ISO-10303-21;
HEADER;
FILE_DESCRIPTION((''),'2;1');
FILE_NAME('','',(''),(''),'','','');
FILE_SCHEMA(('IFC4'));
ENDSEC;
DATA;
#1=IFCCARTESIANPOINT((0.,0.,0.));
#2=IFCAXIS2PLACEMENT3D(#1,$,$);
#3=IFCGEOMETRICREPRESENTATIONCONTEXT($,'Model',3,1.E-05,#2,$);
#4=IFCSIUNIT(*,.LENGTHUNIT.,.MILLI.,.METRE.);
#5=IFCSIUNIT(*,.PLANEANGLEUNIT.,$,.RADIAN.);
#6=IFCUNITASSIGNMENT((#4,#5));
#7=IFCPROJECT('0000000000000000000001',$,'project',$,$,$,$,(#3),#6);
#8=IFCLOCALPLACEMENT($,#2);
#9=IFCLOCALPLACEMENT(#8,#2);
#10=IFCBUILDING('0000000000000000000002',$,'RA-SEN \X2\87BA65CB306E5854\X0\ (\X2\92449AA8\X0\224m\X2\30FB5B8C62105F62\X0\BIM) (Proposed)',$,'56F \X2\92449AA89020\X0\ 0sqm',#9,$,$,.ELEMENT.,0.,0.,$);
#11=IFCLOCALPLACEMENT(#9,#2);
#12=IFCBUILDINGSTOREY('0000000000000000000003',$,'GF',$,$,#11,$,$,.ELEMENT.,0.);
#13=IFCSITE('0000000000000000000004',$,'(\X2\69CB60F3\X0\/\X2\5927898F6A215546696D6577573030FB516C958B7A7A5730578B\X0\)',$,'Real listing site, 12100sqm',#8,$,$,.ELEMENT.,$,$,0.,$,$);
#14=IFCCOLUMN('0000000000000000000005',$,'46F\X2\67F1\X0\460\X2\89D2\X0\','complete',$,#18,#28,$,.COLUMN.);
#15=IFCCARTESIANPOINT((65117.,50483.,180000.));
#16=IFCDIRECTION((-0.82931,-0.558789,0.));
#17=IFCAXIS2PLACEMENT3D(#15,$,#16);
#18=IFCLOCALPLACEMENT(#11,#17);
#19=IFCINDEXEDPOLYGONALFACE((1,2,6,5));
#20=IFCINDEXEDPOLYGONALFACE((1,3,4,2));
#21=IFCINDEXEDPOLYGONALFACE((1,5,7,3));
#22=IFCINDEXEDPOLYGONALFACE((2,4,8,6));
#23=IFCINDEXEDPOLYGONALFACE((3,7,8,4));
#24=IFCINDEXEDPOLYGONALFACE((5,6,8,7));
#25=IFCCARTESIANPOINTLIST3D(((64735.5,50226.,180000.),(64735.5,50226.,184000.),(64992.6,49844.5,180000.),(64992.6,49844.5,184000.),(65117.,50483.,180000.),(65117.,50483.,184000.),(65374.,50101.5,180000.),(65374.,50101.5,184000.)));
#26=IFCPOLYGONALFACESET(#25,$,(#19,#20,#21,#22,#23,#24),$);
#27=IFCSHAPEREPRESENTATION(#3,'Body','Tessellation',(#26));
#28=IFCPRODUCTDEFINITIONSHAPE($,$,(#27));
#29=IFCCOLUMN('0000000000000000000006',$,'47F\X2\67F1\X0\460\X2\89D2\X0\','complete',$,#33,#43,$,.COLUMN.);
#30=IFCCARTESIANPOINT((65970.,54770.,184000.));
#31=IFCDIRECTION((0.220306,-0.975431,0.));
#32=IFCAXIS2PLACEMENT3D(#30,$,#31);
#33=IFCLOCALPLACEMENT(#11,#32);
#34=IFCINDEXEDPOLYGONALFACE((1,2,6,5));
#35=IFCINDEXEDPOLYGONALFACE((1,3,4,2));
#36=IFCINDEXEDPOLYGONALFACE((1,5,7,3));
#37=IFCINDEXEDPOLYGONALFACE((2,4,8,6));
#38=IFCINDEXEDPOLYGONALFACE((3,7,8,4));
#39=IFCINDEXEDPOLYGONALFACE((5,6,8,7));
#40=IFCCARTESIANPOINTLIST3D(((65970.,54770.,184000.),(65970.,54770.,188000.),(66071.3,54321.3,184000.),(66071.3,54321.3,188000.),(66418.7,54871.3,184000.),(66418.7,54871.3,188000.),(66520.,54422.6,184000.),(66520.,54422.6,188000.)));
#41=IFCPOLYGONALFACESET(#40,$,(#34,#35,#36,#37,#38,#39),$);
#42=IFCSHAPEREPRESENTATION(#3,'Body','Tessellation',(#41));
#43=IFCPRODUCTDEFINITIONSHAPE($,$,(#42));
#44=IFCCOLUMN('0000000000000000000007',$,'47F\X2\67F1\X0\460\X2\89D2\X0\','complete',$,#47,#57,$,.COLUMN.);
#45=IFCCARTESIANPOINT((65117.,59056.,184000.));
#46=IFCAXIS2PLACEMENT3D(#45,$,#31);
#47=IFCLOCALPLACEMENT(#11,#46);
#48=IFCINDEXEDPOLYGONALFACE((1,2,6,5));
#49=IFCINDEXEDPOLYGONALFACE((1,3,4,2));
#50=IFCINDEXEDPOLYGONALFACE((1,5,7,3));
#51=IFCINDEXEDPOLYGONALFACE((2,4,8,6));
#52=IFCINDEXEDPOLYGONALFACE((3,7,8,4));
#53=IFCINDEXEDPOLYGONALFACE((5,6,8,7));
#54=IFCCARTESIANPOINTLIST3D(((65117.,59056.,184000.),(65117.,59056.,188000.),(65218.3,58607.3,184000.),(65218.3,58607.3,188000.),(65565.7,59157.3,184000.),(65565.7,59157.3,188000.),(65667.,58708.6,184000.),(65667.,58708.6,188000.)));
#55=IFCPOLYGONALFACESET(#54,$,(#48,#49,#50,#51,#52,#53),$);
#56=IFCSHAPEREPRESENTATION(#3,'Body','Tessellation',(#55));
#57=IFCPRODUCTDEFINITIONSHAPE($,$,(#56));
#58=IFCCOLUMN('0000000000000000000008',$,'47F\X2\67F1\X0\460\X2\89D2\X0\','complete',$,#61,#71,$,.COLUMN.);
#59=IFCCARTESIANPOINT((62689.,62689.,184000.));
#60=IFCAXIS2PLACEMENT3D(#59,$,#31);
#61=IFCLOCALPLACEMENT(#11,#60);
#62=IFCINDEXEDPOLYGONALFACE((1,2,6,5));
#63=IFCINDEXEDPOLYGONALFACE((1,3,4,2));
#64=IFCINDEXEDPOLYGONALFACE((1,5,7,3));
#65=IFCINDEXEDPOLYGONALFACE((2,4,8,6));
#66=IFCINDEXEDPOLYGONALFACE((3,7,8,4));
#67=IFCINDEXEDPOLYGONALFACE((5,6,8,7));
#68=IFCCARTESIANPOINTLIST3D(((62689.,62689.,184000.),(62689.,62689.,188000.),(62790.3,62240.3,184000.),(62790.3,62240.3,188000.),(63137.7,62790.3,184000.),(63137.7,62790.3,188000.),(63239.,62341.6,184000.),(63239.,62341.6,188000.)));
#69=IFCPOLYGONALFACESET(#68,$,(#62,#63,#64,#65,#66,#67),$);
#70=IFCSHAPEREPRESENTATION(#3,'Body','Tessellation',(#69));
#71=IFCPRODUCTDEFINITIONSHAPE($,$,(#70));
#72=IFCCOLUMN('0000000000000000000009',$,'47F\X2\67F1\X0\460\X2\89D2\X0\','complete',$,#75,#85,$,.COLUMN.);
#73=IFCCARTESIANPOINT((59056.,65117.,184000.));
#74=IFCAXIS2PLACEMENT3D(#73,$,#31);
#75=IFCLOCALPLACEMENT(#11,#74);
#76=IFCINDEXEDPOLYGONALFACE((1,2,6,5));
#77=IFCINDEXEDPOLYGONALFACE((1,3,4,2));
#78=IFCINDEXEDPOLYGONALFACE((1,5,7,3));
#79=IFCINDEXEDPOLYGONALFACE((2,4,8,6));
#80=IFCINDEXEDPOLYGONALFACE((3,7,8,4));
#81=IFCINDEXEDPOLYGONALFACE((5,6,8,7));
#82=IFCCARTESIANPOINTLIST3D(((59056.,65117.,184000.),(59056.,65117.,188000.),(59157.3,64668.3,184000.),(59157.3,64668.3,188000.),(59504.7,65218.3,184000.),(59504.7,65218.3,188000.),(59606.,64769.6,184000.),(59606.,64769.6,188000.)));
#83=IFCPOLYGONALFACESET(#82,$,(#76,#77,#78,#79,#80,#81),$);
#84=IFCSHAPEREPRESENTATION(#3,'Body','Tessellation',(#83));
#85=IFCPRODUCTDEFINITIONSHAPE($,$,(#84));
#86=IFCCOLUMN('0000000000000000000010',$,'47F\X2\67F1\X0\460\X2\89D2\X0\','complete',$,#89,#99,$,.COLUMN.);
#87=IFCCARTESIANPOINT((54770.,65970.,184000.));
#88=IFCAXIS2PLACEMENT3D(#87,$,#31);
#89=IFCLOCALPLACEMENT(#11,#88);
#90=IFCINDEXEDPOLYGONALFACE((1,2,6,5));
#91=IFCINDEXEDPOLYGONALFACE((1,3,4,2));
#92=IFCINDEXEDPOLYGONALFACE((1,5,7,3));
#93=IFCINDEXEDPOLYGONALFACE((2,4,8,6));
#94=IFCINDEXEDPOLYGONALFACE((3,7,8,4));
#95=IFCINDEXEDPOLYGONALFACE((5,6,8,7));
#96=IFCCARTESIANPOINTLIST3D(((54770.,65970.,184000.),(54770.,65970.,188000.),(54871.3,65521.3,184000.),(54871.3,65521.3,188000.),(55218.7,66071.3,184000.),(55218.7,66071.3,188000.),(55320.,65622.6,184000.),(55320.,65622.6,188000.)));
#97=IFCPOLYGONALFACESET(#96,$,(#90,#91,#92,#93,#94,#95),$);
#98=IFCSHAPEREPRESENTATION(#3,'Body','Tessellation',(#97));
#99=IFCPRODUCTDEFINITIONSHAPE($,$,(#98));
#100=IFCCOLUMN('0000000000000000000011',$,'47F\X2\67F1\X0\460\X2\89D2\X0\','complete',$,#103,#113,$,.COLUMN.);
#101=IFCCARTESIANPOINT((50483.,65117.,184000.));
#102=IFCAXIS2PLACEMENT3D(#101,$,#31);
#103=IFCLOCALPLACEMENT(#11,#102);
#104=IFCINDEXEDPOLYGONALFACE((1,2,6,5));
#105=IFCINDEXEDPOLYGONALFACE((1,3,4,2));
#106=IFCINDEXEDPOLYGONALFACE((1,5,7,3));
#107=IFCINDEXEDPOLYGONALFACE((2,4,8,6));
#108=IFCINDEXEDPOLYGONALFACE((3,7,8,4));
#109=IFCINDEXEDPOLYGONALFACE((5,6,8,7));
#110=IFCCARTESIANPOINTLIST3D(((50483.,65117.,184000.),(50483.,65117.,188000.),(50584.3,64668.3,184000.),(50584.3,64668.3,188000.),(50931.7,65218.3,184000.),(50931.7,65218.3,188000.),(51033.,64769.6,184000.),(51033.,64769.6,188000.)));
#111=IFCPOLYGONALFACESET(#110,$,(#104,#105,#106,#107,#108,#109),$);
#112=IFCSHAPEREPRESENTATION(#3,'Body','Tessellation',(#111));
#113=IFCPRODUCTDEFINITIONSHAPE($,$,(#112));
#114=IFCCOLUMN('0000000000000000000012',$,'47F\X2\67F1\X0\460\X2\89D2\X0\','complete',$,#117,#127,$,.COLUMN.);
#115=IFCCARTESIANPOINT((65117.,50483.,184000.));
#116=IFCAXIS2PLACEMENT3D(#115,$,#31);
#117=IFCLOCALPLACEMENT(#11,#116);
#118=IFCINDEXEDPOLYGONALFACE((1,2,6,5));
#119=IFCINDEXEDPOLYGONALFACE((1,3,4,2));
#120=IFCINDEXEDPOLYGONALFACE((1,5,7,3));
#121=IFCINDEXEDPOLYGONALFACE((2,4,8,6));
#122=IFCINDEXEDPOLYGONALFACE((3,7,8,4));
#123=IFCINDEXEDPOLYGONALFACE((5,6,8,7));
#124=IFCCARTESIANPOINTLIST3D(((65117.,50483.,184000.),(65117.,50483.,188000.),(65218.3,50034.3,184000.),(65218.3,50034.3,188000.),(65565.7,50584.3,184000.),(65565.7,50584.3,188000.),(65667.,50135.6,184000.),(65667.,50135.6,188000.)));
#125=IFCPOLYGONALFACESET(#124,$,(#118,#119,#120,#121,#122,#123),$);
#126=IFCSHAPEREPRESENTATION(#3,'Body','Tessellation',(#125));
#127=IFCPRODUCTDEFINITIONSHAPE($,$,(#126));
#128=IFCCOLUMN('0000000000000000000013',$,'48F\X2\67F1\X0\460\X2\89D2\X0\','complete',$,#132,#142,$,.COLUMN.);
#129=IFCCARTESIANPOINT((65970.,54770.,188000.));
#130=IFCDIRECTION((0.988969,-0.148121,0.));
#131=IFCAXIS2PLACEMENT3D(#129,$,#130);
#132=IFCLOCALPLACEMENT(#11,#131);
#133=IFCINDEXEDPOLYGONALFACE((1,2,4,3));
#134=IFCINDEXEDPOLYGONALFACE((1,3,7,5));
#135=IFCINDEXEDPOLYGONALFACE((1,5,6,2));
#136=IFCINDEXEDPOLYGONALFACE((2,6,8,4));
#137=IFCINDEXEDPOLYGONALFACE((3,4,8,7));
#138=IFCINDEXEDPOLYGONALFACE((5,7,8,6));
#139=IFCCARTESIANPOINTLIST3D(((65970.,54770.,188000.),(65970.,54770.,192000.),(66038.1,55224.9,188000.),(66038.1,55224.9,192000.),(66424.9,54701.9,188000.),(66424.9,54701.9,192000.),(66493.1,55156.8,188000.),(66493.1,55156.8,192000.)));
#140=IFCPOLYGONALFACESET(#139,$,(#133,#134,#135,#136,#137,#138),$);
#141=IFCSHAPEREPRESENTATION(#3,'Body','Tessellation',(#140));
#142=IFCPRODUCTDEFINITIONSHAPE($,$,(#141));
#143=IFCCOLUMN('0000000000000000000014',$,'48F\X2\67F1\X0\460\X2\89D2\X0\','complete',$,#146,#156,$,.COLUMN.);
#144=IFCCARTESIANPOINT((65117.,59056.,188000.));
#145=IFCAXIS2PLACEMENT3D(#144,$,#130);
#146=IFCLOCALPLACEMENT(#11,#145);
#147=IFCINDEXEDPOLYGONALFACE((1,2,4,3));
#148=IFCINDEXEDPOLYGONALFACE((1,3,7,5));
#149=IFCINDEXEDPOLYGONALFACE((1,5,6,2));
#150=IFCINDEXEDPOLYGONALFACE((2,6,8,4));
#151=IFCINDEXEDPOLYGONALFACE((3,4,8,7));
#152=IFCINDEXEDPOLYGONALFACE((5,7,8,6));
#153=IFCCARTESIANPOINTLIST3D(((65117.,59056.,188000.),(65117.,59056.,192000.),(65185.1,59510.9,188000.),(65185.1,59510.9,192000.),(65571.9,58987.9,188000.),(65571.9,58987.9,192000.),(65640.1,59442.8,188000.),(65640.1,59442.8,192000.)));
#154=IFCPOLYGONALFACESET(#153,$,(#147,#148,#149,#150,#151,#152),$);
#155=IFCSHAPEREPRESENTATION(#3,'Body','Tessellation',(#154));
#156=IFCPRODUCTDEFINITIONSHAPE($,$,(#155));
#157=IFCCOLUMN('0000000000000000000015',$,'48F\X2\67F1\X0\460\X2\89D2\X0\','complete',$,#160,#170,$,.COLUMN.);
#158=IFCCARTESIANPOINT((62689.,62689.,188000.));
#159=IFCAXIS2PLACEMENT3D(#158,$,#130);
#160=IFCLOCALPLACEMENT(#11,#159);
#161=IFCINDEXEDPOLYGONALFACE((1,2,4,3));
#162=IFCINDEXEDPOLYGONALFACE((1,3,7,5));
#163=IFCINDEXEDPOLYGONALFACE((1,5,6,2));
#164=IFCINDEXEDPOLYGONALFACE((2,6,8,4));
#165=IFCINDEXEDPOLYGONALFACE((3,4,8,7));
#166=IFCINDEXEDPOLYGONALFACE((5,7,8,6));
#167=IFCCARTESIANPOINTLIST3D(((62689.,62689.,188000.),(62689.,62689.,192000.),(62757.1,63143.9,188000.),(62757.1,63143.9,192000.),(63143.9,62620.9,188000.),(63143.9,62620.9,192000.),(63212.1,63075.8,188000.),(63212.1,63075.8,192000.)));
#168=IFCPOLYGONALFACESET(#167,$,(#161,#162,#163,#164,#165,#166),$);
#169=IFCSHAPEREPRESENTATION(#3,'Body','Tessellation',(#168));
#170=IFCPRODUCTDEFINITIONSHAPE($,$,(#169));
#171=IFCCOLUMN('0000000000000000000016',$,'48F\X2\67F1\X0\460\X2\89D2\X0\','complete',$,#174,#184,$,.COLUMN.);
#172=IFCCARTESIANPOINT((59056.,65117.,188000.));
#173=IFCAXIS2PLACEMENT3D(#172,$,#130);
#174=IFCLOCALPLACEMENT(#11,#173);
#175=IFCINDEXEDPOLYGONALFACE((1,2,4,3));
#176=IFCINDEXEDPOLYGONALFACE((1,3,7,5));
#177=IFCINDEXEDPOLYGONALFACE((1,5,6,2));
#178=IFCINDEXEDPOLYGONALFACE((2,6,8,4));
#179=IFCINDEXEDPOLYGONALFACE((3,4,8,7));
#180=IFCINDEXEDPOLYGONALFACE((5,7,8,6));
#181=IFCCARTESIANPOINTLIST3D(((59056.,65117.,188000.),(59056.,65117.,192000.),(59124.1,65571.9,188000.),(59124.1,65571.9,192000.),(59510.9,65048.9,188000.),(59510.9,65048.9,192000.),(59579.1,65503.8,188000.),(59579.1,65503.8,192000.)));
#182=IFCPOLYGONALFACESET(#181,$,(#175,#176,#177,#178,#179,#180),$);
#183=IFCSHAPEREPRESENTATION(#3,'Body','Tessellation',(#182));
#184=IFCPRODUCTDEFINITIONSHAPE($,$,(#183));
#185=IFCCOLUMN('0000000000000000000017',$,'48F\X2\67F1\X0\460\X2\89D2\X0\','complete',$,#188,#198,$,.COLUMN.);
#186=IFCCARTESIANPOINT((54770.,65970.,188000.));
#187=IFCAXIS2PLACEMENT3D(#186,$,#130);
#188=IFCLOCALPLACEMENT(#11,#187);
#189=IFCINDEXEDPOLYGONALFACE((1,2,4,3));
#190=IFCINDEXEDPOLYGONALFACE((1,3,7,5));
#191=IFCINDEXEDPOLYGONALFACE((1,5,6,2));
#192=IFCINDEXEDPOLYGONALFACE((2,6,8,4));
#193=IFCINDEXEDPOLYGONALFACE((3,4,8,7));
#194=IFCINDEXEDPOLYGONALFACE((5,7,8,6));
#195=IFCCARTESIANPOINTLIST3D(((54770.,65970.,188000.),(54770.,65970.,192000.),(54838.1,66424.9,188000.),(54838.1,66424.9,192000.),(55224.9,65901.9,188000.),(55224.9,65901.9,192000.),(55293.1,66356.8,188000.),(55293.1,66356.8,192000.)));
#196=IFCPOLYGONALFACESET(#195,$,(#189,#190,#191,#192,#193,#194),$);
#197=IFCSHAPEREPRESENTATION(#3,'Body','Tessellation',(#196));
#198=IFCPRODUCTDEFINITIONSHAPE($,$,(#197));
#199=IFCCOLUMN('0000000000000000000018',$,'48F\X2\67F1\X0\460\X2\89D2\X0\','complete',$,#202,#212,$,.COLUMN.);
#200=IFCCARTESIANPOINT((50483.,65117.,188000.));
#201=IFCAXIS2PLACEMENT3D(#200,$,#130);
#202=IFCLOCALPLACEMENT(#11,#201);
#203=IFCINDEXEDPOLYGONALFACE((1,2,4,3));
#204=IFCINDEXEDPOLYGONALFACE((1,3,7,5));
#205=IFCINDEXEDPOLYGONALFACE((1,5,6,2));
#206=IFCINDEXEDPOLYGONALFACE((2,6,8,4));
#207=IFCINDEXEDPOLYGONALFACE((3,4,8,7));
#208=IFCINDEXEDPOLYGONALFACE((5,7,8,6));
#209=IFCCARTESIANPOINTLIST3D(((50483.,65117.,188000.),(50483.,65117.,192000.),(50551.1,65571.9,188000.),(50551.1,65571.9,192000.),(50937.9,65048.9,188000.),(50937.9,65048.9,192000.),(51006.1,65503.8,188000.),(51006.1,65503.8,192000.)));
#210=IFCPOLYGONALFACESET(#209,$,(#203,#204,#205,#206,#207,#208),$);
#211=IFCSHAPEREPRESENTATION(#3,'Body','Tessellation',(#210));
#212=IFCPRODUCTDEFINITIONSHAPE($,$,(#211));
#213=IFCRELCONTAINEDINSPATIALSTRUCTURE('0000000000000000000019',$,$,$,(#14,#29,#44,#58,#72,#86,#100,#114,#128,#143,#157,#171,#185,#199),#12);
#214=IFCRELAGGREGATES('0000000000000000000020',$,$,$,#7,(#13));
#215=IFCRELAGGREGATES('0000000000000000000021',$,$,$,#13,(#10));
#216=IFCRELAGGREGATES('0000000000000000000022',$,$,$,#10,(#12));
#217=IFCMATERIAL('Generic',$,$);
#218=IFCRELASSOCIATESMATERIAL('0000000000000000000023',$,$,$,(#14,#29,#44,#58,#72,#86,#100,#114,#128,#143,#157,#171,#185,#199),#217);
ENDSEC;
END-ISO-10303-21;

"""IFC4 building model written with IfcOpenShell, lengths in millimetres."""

from ifc_helpers import new_model, si_unit, frame, frame_2d, origin, place, context, project, spatial, rectangle, extrude, material, element, save


model = new_model("IFC4")

# Units and contexts
model_context = context("Model", 3, precision=1e-05, world=origin())
ifc_project = project(units=[si_unit("LENGTHUNIT", "METRE", prefix="MILLI"), si_unit("PLANEANGLEUNIT", "RADIAN")], contexts=[model_context])

# Site, building, storey
site_placement = place(None, origin())
site = spatial("IfcSite", under=ifc_project, at=site_placement, Name="(構想/大規模商業敷地・公開空地型)", ObjectType="Real listing site, 12100sqm", CompositionType="ELEMENT", RefElevation=0.0)
building_placement = place(site_placement, origin())
building = spatial("IfcBuilding", under=site, at=building_placement, Name="RA-SEN 螺旋の塔 (鉄骨224m・完成形BIM) (Proposed)", ObjectType="56F 鉄骨造 0sqm", CompositionType="ELEMENT", ElevationOfRefHeight=0.0, ElevationOfTerrain=0.0)
storey_placement = place(building_placement, origin())
storey = spatial("IfcBuildingStorey", under=building, at=storey_placement, Name="GF", CompositionType="ELEMENT", Elevation=0.0)

# Columns
ifc_material = material(Name="Generic")
column_1_placement = place(storey_placement, frame((65117.0, 50483.0, 180000.0), x_axis=(-0.82931, -0.558789, 0.0)))
element("IfcColumn", 1, at=column_1_placement, inside=storey, material=ifc_material, Name="46F柱460角", Description="complete", PredefinedType="COLUMN", context=model_context, shape_type="SweptSolid", body=[
    extrude(rectangle(XDim=460.0, YDim=460.0, at=frame_2d((230.0, 230.0))), frame((65117.0, 50483.0, 180000.0), x_axis=(-0.82931, -0.558789, 0.0)), (0.0, 0.0, 1.0), 4000.0),
])
column_2_placement = place(storey_placement, frame((65970.0, 54770.0, 184000.0), x_axis=(0.220306, -0.975431, 0.0)))
element("IfcColumn", 2, at=column_2_placement, inside=storey, material=ifc_material, Name="47F柱460角", Description="complete", PredefinedType="COLUMN", context=model_context, shape_type="SweptSolid", body=[
    extrude(rectangle(XDim=460.0, YDim=460.0, at=frame_2d((230.0, 230.0))), frame((65970.0, 54770.0, 184000.0), x_axis=(0.220306, -0.975431, 0.0)), (0.0, 0.0, 1.0), 4000.0),
])
column_3_placement = place(storey_placement, frame((65117.0, 59056.0, 184000.0), x_axis=(0.220306, -0.975431, 0.0)))
element("IfcColumn", 3, at=column_3_placement, inside=storey, material=ifc_material, Name="47F柱460角", Description="complete", PredefinedType="COLUMN", context=model_context, shape_type="SweptSolid", body=[
    extrude(rectangle(XDim=460.0, YDim=460.0, at=frame_2d((230.0, 230.0))), frame((65117.0, 59056.0, 184000.0), x_axis=(0.220306, -0.975431, 0.0)), (0.0, 0.0, 1.0), 4000.0),
])
column_4_placement = place(storey_placement, frame((62689.0, 62689.0, 184000.0), x_axis=(0.220306, -0.975431, 0.0)))
element("IfcColumn", 4, at=column_4_placement, inside=storey, material=ifc_material, Name="47F柱460角", Description="complete", PredefinedType="COLUMN", context=model_context, shape_type="SweptSolid", body=[
    extrude(rectangle(XDim=460.0, YDim=460.0, at=frame_2d((230.0, 230.0))), frame((62689.0, 62689.0, 184000.0), x_axis=(0.220306, -0.975431, 0.0)), (0.0, 0.0, 1.0), 4000.0),
])
column_5_placement = place(storey_placement, frame((59056.0, 65117.0, 184000.0), x_axis=(0.220306, -0.975431, 0.0)))
element("IfcColumn", 5, at=column_5_placement, inside=storey, material=ifc_material, Name="47F柱460角", Description="complete", PredefinedType="COLUMN", context=model_context, shape_type="SweptSolid", body=[
    extrude(rectangle(XDim=460.0, YDim=460.0, at=frame_2d((230.0, 230.0))), frame((59056.0, 65117.0, 184000.0), x_axis=(0.220306, -0.975431, 0.0)), (0.0, 0.0, 1.0), 4000.0),
])
column_6_placement = place(storey_placement, frame((54770.0, 65970.0, 184000.0), x_axis=(0.220306, -0.975431, 0.0)))
element("IfcColumn", 6, at=column_6_placement, inside=storey, material=ifc_material, Name="47F柱460角", Description="complete", PredefinedType="COLUMN", context=model_context, shape_type="SweptSolid", body=[
    extrude(rectangle(XDim=460.0, YDim=460.0, at=frame_2d((230.0, 230.0))), frame((54770.0, 65970.0, 184000.0), x_axis=(0.220306, -0.975431, 0.0)), (0.0, 0.0, 1.0), 4000.0),
])
column_7_placement = place(storey_placement, frame((50483.0, 65117.0, 184000.0), x_axis=(0.220306, -0.975431, 0.0)))
element("IfcColumn", 7, at=column_7_placement, inside=storey, material=ifc_material, Name="47F柱460角", Description="complete", PredefinedType="COLUMN", context=model_context, shape_type="SweptSolid", body=[
    extrude(rectangle(XDim=460.0, YDim=460.0, at=frame_2d((230.0, 230.0))), frame((50483.0, 65117.0, 184000.0), x_axis=(0.220306, -0.975431, 0.0)), (0.0, 0.0, 1.0), 4000.0),
])
column_8_placement = place(storey_placement, frame((65117.0, 50483.0, 184000.0), x_axis=(0.220306, -0.975431, 0.0)))
element("IfcColumn", 8, at=column_8_placement, inside=storey, material=ifc_material, Name="47F柱460角", Description="complete", PredefinedType="COLUMN", context=model_context, shape_type="SweptSolid", body=[
    extrude(rectangle(XDim=460.0, YDim=460.0, at=frame_2d((230.0, 230.0))), frame((65117.0, 50483.0, 184000.0), x_axis=(0.220306, -0.975431, 0.0)), (0.0, 0.0, 1.0), 4000.0),
])
column_9_placement = place(storey_placement, frame((65970.0, 54770.0, 188000.0), x_axis=(0.988969, -0.148121, 0.0)))
element("IfcColumn", 9, at=column_9_placement, inside=storey, material=ifc_material, Name="48F柱460角", Description="complete", PredefinedType="COLUMN", context=model_context, shape_type="SweptSolid", body=[
    extrude(rectangle(XDim=460.0, YDim=460.0, at=frame_2d((230.0, 230.0))), frame((65970.0, 54770.0, 188000.0), x_axis=(0.988969, -0.148121, 0.0)), (0.0, 0.0, 1.0), 4000.0),
])
column_10_placement = place(storey_placement, frame((65117.0, 59056.0, 188000.0), x_axis=(0.988969, -0.148121, 0.0)))
element("IfcColumn", 10, at=column_10_placement, inside=storey, material=ifc_material, Name="48F柱460角", Description="complete", PredefinedType="COLUMN", context=model_context, shape_type="SweptSolid", body=[
    extrude(rectangle(XDim=460.0, YDim=460.0, at=frame_2d((230.0, 230.0))), frame((65117.0, 59056.0, 188000.0), x_axis=(0.988969, -0.148121, 0.0)), (0.0, 0.0, 1.0), 4000.0),
])
column_11_placement = place(storey_placement, frame((62689.0, 62689.0, 188000.0), x_axis=(0.988969, -0.148121, 0.0)))
element("IfcColumn", 11, at=column_11_placement, inside=storey, material=ifc_material, Name="48F柱460角", Description="complete", PredefinedType="COLUMN", context=model_context, shape_type="SweptSolid", body=[
    extrude(rectangle(XDim=460.0, YDim=460.0, at=frame_2d((230.0, 230.0))), frame((62689.0, 62689.0, 188000.0), x_axis=(0.988969, -0.148121, 0.0)), (0.0, 0.0, 1.0), 4000.0),
])
column_12_placement = place(storey_placement, frame((59056.0, 65117.0, 188000.0), x_axis=(0.988969, -0.148121, 0.0)))
element("IfcColumn", 12, at=column_12_placement, inside=storey, material=ifc_material, Name="48F柱460角", Description="complete", PredefinedType="COLUMN", context=model_context, shape_type="SweptSolid", body=[
    extrude(rectangle(XDim=460.0, YDim=460.0, at=frame_2d((230.0, 230.0))), frame((59056.0, 65117.0, 188000.0), x_axis=(0.988969, -0.148121, 0.0)), (0.0, 0.0, 1.0), 4000.0),
])
column_13_placement = place(storey_placement, frame((54770.0, 65970.0, 188000.0), x_axis=(0.988969, -0.148121, 0.0)))
element("IfcColumn", 13, at=column_13_placement, inside=storey, material=ifc_material, Name="48F柱460角", Description="complete", PredefinedType="COLUMN", context=model_context, shape_type="SweptSolid", body=[
    extrude(rectangle(XDim=460.0, YDim=460.0, at=frame_2d((230.0, 230.0))), frame((54770.0, 65970.0, 188000.0), x_axis=(0.988969, -0.148121, 0.0)), (0.0, 0.0, 1.0), 4000.0),
])
column_14_placement = place(storey_placement, frame((50483.0, 65117.0, 188000.0), x_axis=(0.988969, -0.148121, 0.0)))
element("IfcColumn", 14, at=column_14_placement, inside=storey, material=ifc_material, Name="48F柱460角", Description="complete", PredefinedType="COLUMN", context=model_context, shape_type="SweptSolid", body=[
    extrude(rectangle(XDim=460.0, YDim=460.0, at=frame_2d((230.0, 230.0))), frame((50483.0, 65117.0, 188000.0), x_axis=(0.988969, -0.148121, 0.0)), (0.0, 0.0, 1.0), 4000.0),
])

save(model, "model.ifc")
